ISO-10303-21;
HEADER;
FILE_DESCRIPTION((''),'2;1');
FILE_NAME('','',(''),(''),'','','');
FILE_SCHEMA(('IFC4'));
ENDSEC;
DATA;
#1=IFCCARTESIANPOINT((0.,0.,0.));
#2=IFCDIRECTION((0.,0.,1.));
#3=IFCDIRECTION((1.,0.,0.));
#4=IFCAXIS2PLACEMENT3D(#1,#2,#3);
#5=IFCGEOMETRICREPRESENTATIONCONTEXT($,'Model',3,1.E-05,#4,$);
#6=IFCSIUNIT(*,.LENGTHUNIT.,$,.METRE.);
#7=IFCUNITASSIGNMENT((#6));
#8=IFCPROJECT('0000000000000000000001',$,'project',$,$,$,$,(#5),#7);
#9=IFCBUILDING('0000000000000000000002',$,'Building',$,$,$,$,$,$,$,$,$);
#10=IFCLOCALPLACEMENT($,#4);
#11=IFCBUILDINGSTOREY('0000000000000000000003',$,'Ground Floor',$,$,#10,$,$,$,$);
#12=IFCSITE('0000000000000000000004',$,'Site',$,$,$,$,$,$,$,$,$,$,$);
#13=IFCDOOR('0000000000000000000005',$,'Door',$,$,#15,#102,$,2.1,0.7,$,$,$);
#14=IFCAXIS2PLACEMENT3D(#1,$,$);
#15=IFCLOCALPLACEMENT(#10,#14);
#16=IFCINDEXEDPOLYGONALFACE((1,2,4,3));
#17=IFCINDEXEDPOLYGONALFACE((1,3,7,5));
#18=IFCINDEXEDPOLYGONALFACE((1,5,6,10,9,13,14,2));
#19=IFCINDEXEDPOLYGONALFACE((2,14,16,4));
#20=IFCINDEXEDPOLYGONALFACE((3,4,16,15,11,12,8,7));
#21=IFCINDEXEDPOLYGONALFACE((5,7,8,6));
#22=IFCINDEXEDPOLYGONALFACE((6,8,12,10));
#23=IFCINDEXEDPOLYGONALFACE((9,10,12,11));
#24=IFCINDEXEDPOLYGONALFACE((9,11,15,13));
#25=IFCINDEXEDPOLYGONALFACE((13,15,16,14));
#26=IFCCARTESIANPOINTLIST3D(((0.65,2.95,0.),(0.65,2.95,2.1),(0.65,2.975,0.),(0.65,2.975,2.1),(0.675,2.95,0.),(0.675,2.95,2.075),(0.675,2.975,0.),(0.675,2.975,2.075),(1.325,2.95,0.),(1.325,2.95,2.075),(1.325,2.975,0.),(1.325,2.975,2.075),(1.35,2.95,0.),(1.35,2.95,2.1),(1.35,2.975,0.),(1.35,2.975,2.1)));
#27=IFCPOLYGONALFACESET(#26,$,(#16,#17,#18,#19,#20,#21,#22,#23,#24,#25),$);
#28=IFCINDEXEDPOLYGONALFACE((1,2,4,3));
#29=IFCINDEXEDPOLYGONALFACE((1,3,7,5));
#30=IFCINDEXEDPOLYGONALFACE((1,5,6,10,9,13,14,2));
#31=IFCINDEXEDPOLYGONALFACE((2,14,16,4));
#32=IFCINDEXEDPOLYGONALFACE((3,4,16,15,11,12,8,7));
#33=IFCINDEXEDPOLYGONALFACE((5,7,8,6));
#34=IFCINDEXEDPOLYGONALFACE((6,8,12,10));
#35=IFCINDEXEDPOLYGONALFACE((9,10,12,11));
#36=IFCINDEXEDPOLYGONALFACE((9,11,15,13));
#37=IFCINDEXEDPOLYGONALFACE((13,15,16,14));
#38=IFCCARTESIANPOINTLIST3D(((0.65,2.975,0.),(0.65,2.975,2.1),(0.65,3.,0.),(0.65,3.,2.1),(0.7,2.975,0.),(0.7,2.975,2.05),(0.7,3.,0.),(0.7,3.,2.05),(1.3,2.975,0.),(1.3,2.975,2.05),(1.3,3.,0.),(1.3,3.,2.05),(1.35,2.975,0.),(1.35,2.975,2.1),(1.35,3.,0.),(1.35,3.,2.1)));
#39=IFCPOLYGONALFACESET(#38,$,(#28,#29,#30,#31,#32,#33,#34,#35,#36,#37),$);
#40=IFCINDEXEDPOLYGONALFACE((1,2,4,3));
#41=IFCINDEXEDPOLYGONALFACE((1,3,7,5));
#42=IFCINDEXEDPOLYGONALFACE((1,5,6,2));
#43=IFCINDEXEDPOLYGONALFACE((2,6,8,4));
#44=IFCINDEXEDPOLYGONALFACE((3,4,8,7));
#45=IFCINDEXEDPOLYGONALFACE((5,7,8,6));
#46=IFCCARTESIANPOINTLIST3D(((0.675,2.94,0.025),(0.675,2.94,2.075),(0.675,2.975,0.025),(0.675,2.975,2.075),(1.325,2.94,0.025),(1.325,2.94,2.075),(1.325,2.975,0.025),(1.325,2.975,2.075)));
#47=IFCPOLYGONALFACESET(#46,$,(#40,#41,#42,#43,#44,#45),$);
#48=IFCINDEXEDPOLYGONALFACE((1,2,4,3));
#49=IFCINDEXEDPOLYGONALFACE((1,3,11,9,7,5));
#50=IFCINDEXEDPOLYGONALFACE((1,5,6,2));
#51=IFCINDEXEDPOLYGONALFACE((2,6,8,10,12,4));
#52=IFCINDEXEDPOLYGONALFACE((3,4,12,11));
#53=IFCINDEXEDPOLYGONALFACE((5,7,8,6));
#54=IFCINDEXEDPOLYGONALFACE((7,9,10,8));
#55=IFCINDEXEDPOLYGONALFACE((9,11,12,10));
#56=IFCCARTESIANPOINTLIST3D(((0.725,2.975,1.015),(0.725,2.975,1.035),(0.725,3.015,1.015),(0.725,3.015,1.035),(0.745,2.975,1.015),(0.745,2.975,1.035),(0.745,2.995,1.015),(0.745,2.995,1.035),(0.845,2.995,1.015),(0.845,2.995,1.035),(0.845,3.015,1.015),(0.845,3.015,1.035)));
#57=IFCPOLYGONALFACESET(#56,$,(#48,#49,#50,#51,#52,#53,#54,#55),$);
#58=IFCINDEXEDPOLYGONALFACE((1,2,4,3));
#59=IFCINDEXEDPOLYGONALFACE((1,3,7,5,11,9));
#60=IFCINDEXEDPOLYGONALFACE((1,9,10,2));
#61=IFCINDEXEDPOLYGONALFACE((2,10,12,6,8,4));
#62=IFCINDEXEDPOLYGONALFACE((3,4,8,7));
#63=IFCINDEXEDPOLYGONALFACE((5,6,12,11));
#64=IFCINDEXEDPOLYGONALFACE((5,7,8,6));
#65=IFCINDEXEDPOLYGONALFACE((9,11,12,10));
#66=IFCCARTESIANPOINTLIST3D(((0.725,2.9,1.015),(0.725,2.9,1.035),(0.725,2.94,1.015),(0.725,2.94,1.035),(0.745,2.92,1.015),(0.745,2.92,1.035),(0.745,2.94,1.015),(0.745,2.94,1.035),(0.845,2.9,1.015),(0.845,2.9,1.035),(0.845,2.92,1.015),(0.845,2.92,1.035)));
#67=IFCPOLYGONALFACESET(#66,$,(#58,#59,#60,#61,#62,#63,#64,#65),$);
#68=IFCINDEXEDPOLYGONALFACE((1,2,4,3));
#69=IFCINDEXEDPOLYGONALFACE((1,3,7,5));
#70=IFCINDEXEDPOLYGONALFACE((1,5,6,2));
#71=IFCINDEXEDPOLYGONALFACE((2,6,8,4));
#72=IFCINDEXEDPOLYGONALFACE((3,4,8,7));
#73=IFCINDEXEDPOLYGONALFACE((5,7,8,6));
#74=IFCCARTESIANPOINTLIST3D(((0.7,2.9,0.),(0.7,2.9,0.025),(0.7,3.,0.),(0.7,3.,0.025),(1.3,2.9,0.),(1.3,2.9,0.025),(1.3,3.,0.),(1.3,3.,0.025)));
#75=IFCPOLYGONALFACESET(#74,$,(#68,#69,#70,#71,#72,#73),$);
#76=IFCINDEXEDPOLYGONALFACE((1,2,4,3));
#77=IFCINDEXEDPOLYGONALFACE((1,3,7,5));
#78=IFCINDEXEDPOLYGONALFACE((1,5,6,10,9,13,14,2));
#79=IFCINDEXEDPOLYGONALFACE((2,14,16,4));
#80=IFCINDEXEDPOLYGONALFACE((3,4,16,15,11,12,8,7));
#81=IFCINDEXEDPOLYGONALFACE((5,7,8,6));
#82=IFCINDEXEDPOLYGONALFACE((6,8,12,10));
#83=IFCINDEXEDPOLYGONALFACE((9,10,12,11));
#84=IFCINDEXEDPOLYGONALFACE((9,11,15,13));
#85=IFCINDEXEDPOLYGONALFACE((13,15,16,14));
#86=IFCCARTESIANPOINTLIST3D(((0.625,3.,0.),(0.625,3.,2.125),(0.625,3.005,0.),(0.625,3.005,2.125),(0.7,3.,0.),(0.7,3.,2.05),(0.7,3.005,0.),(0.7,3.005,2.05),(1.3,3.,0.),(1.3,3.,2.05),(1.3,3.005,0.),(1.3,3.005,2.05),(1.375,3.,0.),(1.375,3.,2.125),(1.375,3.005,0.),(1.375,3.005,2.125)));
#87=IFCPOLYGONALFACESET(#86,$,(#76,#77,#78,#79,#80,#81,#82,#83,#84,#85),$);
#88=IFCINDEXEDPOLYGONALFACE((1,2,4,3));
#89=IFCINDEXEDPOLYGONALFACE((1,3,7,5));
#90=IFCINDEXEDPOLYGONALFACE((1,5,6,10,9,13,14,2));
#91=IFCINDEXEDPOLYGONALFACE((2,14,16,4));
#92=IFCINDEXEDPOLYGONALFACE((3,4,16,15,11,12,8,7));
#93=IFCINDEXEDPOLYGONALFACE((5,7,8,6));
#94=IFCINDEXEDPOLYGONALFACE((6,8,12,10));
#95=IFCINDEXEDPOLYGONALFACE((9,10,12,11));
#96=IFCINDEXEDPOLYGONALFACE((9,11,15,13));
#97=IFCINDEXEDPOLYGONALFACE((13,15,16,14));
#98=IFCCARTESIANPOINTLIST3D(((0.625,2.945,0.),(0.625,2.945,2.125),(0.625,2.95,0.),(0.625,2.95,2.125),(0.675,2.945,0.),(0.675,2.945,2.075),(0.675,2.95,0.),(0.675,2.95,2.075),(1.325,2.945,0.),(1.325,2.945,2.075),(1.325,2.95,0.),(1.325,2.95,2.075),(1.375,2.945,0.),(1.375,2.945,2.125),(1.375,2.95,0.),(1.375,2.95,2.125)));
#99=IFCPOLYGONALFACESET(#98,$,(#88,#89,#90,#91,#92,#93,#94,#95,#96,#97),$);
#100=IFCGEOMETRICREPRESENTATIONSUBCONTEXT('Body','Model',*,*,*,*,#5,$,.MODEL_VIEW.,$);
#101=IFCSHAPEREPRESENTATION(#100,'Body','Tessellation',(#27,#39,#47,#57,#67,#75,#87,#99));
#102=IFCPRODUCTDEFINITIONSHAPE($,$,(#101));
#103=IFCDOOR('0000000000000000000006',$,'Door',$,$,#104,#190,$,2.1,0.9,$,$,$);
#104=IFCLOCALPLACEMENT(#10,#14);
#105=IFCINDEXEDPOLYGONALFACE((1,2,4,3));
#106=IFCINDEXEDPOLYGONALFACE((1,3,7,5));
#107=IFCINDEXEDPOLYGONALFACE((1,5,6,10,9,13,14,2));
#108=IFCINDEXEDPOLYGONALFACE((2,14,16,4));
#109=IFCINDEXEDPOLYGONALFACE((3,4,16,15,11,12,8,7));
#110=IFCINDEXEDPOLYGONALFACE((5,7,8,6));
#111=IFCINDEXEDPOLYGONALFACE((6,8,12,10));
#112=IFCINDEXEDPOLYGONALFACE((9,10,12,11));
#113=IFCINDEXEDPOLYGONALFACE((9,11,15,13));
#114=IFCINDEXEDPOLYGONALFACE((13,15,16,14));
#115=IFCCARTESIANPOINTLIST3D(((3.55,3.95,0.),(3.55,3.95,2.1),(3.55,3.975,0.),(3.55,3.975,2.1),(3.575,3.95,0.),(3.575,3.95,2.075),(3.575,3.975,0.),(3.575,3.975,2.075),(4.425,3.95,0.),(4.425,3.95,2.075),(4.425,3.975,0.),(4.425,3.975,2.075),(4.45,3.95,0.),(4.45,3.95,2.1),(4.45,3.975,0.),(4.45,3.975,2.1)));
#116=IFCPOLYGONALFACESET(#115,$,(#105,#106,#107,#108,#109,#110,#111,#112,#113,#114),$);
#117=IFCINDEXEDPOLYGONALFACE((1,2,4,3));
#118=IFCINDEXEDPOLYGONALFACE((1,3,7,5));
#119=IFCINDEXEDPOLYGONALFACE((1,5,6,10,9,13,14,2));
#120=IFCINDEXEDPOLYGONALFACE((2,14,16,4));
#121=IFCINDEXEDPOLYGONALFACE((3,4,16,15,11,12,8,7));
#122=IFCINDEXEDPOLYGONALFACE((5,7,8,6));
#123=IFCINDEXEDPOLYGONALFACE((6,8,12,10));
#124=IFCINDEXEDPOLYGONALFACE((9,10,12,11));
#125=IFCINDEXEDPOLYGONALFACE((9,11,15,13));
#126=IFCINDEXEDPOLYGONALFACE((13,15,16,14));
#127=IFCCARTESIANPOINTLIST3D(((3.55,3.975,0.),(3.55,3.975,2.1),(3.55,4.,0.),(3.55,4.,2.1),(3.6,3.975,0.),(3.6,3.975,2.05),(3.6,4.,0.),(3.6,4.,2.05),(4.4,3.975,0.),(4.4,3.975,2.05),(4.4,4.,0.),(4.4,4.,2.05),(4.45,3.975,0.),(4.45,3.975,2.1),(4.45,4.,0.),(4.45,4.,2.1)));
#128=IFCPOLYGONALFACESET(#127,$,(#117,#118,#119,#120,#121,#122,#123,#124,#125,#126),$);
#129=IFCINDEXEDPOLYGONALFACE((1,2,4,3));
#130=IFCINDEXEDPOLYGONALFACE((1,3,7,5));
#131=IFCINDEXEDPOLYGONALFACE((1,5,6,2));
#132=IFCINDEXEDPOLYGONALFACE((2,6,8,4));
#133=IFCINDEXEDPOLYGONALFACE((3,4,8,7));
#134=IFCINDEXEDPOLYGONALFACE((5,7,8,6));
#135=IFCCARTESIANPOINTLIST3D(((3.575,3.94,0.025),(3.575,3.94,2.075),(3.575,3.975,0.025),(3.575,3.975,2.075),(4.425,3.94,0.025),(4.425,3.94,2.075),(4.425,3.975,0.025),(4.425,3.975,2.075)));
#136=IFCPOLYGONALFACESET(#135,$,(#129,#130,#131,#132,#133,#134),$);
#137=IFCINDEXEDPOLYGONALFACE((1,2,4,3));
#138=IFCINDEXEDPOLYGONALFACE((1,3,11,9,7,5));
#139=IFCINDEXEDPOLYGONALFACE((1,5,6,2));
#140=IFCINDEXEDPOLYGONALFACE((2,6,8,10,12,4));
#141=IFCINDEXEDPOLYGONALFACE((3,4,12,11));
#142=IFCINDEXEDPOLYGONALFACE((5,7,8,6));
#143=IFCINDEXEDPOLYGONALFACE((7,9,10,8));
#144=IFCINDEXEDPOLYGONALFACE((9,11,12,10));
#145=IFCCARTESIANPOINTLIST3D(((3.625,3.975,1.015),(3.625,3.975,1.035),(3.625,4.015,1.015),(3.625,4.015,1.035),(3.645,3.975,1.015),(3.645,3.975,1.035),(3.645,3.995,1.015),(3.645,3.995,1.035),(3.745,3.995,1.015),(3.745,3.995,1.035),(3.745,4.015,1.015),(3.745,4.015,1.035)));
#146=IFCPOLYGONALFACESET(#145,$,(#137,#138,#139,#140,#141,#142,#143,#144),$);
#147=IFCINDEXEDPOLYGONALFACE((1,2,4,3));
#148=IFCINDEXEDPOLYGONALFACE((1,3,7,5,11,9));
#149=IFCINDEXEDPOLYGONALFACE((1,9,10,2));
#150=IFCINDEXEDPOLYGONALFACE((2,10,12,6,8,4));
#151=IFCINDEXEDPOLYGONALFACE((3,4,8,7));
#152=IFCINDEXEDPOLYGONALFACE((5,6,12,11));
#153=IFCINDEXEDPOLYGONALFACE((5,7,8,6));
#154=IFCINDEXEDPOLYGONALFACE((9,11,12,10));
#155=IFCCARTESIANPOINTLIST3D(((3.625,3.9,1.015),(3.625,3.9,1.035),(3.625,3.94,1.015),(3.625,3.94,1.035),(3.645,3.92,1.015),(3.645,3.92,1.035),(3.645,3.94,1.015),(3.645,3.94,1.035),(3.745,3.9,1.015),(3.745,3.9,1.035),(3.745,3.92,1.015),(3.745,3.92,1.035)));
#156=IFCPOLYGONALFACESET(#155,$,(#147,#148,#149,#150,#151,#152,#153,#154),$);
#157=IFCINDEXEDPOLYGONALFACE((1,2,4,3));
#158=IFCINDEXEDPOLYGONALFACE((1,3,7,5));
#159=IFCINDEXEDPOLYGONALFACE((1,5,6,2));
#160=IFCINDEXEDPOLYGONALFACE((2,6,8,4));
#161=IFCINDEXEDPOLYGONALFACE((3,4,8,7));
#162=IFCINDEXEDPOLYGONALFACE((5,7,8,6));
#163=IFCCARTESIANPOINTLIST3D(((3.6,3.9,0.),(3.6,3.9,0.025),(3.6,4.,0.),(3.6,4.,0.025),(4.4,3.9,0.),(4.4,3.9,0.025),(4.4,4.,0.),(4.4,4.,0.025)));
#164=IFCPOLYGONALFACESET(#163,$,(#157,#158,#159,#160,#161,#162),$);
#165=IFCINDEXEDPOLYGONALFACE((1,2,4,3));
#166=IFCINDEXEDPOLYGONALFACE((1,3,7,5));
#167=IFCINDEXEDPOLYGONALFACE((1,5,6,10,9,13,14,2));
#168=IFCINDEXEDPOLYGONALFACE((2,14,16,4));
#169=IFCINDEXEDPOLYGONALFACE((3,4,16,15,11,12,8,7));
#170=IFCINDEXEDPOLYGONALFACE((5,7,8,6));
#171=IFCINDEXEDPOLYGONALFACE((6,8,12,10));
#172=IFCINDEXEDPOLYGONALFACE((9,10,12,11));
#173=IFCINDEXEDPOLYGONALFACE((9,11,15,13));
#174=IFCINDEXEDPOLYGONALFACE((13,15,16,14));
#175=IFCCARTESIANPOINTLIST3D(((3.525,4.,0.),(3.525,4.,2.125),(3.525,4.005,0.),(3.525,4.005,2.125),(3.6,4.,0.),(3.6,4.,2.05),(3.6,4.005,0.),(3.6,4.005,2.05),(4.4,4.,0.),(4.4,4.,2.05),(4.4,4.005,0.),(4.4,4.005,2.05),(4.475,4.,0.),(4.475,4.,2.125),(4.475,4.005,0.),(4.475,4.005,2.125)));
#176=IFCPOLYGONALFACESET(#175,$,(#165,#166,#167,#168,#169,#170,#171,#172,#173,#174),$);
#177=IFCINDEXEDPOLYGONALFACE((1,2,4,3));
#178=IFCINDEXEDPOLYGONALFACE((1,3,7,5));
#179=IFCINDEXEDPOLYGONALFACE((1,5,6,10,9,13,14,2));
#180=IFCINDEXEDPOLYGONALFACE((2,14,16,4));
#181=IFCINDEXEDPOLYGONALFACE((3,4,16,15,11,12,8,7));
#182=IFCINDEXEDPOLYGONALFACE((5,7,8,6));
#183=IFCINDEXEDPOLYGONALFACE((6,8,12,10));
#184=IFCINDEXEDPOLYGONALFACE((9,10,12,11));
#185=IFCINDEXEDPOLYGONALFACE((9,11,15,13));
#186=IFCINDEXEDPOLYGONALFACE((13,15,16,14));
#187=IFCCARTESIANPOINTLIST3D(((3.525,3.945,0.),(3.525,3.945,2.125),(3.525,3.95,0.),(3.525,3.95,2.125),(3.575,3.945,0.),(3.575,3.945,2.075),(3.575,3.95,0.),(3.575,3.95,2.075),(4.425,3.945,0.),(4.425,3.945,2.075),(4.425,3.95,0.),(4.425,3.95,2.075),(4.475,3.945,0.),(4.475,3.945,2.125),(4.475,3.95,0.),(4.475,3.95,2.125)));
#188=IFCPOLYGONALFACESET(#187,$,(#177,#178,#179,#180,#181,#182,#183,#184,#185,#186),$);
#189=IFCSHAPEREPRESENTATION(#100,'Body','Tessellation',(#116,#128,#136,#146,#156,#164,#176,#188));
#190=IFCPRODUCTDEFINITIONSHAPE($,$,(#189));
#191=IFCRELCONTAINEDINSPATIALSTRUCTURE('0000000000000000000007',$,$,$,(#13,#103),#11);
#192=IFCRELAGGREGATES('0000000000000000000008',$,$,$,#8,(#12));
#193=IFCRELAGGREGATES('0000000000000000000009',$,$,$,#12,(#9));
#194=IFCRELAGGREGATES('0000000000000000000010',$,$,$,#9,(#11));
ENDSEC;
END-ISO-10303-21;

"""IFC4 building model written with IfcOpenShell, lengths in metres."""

from ifc_helpers import new_model, si_unit, frame, origin_with_axes, place, context, subcontext, project, spatial, line, indexed_curve, outline, extrude, element, save


model = new_model("IFC4")

# Units and contexts
model_context = context("Model", 3, precision=1e-05, world=origin_with_axes())
body_context = subcontext(model_context, "Body", "Model", "MODEL_VIEW")
ifc_project = project(units=[si_unit("LENGTHUNIT", "METRE")], contexts=[model_context])

# Site, building, storey
site = spatial("IfcSite", under=ifc_project, Name="Site")
building = spatial("IfcBuilding", under=site, Name="Building")
storey_placement = place(None, origin_with_axes())
storey = spatial("IfcBuildingStorey", under=building, at=storey_placement, Name="Ground Floor")

# Doors
door_1_placement = place(storey_placement, frame((1.35, 3.0, 0.0), z_axis=(0.0, 0.0, 1.0), x_axis=(-1.0, 0.0, 0.0)))
element("IfcDoor", 1, at=door_1_placement, inside=storey, Name="Door", OverallHeight=2.1, OverallWidth=0.7, context=body_context, shape_type="SweptSolid", body=[
    extrude(outline(indexed_curve([(0.0, 0.0), (0.0, 2.1), (0.7, 2.1), (0.7, 0.0), (0.675, 0.0), (0.675, 2.075), (0.025, 2.075), (0.025, 0.0)], segments=[line(1, 2, 3, 4, 5, 6, 7, 8, 1)])), frame((0.0, 0.025, 0.0), z_axis=(0.0, -1.0, 0.0), x_axis=(1.0, 0.0, 0.0)), (0.0, 0.0, -1.0), 0.025),
    extrude(outline(indexed_curve([(0.0, 0.0), (0.0, 2.1), (0.7, 2.1), (0.7, 0.0), (0.65, 0.0), (0.65, 2.05), (0.05, 2.05), (0.05, 0.0)], segments=[line(1, 2, 3, 4, 5, 6, 7, 8, 1)])), frame((0.0, 0.0, 0.0), z_axis=(0.0, -1.0, 0.0), x_axis=(1.0, 0.0, 0.0)), (0.0, 0.0, -1.0), 0.025),
    extrude(outline(indexed_curve([(0.0, 0.0), (0.65, 0.0), (0.65, 0.035), (0.0, 0.035)], segments=[line(1, 2, 3, 4, 1)])), frame((0.025, 0.025, 0.025), z_axis=(0.0, 0.0, 1.0), x_axis=(1.0, 0.0, 0.0)), (0.0, 0.0, 1.0), 2.05),
    extrude(outline(indexed_curve([(0.0, 0.0), (0.0, -0.04), (-0.12, -0.04), (-0.12, -0.02), (-0.02, -0.02), (-0.02, 0.0)], segments=[line(1, 2, 3, 4, 5, 6, 1)])), frame((0.625, 0.025, 1.015), z_axis=(0.0, 0.0, 1.0), x_axis=(1.0, 0.0, 0.0)), (0.0, 0.0, 1.0), 0.02),
    extrude(outline(indexed_curve([(0.0, 0.0), (0.0, 0.04), (-0.12, 0.04), (-0.12, 0.02), (-0.02, 0.02), (-0.02, 0.0)], segments=[line(1, 2, 3, 4, 5, 6, 1)])), frame((0.625, 0.06, 1.015), z_axis=(0.0, 0.0, 1.0), x_axis=(1.0, 0.0, 0.0)), (0.0, 0.0, 1.0), 0.02),
    extrude(outline(indexed_curve([(0.0, 0.0), (0.6, 0.0), (0.6, 0.1), (0.0, 0.1)], segments=[line(1, 2, 3, 4, 1)])), frame((0.05, 0.0, 0.0), z_axis=(0.0, 0.0, 1.0), x_axis=(1.0, 0.0, 0.0)), (0.0, 0.0, 1.0), 0.025),
    extrude(outline(indexed_curve([(0.0, 0.0), (0.0, 2.125), (0.75, 2.125), (0.75, 0.0), (0.675, 0.0), (0.675, 2.05), (0.075, 2.05), (0.075, 0.0)], segments=[line(1, 2, 3, 4, 5, 6, 7, 8, 1)])), frame((-0.025, -0.005, 0.0), z_axis=(0.0, -1.0, 0.0), x_axis=(1.0, 0.0, 0.0)), (0.0, 0.0, -1.0), 0.005),
    extrude(outline(indexed_curve([(0.0, 0.0), (0.0, 2.125), (0.75, 2.125), (0.75, 0.0), (0.7, 0.0), (0.7, 2.075), (0.05, 2.075), (0.05, 0.0)], segments=[line(1, 2, 3, 4, 5, 6, 7, 8, 1)])), frame((-0.025, 0.05, 0.0), z_axis=(0.0, -1.0, 0.0), x_axis=(1.0, 0.0, 0.0)), (0.0, 0.0, -1.0), 0.005),
])
door_2_placement = place(storey_placement, frame((4.45, 4.0, 0.0), z_axis=(0.0, 0.0, 1.0), x_axis=(-1.0, 0.0, 0.0)))
element("IfcDoor", 2, at=door_2_placement, inside=storey, Name="Door", OverallHeight=2.1, OverallWidth=0.9, context=body_context, shape_type="SweptSolid", body=[
    extrude(outline(indexed_curve([(0.0, 0.0), (0.0, 2.1), (0.9, 2.1), (0.9, 0.0), (0.875, 0.0), (0.875, 2.075), (0.025, 2.075), (0.025, 0.0)], segments=[line(1, 2, 3, 4, 5, 6, 7, 8, 1)])), frame((0.0, 0.025, 0.0), z_axis=(0.0, -1.0, 0.0), x_axis=(1.0, 0.0, 0.0)), (0.0, 0.0, -1.0), 0.025),
    extrude(outline(indexed_curve([(0.0, 0.0), (0.0, 2.1), (0.9, 2.1), (0.9, 0.0), (0.85, 0.0), (0.85, 2.05), (0.05, 2.05), (0.05, 0.0)], segments=[line(1, 2, 3, 4, 5, 6, 7, 8, 1)])), frame((0.0, 0.0, 0.0), z_axis=(0.0, -1.0, 0.0), x_axis=(1.0, 0.0, 0.0)), (0.0, 0.0, -1.0), 0.025),
    extrude(outline(indexed_curve([(0.0, 0.0), (0.85, 0.0), (0.85, 0.035), (0.0, 0.035)], segments=[line(1, 2, 3, 4, 1)])), frame((0.025, 0.025, 0.025), z_axis=(0.0, 0.0, 1.0), x_axis=(1.0, 0.0, 0.0)), (0.0, 0.0, 1.0), 2.05),
    extrude(outline(indexed_curve([(0.0, 0.0), (0.0, -0.04), (-0.12, -0.04), (-0.12, -0.02), (-0.02, -0.02), (-0.02, 0.0)], segments=[line(1, 2, 3, 4, 5, 6, 1)])), frame((0.825, 0.025, 1.015), z_axis=(0.0, 0.0, 1.0), x_axis=(1.0, 0.0, 0.0)), (0.0, 0.0, 1.0), 0.02),
    extrude(outline(indexed_curve([(0.0, 0.0), (0.0, 0.04), (-0.12, 0.04), (-0.12, 0.02), (-0.02, 0.02), (-0.02, 0.0)], segments=[line(1, 2, 3, 4, 5, 6, 1)])), frame((0.825, 0.06, 1.015), z_axis=(0.0, 0.0, 1.0), x_axis=(1.0, 0.0, 0.0)), (0.0, 0.0, 1.0), 0.02),
    extrude(outline(indexed_curve([(0.0, 0.0), (0.8, 0.0), (0.8, 0.1), (0.0, 0.1)], segments=[line(1, 2, 3, 4, 1)])), frame((0.05, 0.0, 0.0), z_axis=(0.0, 0.0, 1.0), x_axis=(1.0, 0.0, 0.0)), (0.0, 0.0, 1.0), 0.025),
    extrude(outline(indexed_curve([(0.0, 0.0), (0.0, 2.125), (0.95, 2.125), (0.95, 0.0), (0.875, 0.0), (0.875, 2.05), (0.075, 2.05), (0.075, 0.0)], segments=[line(1, 2, 3, 4, 5, 6, 7, 8, 1)])), frame((-0.025, -0.005, 0.0), z_axis=(0.0, -1.0, 0.0), x_axis=(1.0, 0.0, 0.0)), (0.0, 0.0, -1.0), 0.005),
    extrude(outline(indexed_curve([(0.0, 0.0), (0.0, 2.125), (0.95, 2.125), (0.95, 0.0), (0.9, 0.0), (0.9, 2.075), (0.05, 2.075), (0.05, 0.0)], segments=[line(1, 2, 3, 4, 5, 6, 7, 8, 1)])), frame((-0.025, 0.05, 0.0), z_axis=(0.0, -1.0, 0.0), x_axis=(1.0, 0.0, 0.0)), (0.0, 0.0, -1.0), 0.005),
])

save(model, "model.ifc")
